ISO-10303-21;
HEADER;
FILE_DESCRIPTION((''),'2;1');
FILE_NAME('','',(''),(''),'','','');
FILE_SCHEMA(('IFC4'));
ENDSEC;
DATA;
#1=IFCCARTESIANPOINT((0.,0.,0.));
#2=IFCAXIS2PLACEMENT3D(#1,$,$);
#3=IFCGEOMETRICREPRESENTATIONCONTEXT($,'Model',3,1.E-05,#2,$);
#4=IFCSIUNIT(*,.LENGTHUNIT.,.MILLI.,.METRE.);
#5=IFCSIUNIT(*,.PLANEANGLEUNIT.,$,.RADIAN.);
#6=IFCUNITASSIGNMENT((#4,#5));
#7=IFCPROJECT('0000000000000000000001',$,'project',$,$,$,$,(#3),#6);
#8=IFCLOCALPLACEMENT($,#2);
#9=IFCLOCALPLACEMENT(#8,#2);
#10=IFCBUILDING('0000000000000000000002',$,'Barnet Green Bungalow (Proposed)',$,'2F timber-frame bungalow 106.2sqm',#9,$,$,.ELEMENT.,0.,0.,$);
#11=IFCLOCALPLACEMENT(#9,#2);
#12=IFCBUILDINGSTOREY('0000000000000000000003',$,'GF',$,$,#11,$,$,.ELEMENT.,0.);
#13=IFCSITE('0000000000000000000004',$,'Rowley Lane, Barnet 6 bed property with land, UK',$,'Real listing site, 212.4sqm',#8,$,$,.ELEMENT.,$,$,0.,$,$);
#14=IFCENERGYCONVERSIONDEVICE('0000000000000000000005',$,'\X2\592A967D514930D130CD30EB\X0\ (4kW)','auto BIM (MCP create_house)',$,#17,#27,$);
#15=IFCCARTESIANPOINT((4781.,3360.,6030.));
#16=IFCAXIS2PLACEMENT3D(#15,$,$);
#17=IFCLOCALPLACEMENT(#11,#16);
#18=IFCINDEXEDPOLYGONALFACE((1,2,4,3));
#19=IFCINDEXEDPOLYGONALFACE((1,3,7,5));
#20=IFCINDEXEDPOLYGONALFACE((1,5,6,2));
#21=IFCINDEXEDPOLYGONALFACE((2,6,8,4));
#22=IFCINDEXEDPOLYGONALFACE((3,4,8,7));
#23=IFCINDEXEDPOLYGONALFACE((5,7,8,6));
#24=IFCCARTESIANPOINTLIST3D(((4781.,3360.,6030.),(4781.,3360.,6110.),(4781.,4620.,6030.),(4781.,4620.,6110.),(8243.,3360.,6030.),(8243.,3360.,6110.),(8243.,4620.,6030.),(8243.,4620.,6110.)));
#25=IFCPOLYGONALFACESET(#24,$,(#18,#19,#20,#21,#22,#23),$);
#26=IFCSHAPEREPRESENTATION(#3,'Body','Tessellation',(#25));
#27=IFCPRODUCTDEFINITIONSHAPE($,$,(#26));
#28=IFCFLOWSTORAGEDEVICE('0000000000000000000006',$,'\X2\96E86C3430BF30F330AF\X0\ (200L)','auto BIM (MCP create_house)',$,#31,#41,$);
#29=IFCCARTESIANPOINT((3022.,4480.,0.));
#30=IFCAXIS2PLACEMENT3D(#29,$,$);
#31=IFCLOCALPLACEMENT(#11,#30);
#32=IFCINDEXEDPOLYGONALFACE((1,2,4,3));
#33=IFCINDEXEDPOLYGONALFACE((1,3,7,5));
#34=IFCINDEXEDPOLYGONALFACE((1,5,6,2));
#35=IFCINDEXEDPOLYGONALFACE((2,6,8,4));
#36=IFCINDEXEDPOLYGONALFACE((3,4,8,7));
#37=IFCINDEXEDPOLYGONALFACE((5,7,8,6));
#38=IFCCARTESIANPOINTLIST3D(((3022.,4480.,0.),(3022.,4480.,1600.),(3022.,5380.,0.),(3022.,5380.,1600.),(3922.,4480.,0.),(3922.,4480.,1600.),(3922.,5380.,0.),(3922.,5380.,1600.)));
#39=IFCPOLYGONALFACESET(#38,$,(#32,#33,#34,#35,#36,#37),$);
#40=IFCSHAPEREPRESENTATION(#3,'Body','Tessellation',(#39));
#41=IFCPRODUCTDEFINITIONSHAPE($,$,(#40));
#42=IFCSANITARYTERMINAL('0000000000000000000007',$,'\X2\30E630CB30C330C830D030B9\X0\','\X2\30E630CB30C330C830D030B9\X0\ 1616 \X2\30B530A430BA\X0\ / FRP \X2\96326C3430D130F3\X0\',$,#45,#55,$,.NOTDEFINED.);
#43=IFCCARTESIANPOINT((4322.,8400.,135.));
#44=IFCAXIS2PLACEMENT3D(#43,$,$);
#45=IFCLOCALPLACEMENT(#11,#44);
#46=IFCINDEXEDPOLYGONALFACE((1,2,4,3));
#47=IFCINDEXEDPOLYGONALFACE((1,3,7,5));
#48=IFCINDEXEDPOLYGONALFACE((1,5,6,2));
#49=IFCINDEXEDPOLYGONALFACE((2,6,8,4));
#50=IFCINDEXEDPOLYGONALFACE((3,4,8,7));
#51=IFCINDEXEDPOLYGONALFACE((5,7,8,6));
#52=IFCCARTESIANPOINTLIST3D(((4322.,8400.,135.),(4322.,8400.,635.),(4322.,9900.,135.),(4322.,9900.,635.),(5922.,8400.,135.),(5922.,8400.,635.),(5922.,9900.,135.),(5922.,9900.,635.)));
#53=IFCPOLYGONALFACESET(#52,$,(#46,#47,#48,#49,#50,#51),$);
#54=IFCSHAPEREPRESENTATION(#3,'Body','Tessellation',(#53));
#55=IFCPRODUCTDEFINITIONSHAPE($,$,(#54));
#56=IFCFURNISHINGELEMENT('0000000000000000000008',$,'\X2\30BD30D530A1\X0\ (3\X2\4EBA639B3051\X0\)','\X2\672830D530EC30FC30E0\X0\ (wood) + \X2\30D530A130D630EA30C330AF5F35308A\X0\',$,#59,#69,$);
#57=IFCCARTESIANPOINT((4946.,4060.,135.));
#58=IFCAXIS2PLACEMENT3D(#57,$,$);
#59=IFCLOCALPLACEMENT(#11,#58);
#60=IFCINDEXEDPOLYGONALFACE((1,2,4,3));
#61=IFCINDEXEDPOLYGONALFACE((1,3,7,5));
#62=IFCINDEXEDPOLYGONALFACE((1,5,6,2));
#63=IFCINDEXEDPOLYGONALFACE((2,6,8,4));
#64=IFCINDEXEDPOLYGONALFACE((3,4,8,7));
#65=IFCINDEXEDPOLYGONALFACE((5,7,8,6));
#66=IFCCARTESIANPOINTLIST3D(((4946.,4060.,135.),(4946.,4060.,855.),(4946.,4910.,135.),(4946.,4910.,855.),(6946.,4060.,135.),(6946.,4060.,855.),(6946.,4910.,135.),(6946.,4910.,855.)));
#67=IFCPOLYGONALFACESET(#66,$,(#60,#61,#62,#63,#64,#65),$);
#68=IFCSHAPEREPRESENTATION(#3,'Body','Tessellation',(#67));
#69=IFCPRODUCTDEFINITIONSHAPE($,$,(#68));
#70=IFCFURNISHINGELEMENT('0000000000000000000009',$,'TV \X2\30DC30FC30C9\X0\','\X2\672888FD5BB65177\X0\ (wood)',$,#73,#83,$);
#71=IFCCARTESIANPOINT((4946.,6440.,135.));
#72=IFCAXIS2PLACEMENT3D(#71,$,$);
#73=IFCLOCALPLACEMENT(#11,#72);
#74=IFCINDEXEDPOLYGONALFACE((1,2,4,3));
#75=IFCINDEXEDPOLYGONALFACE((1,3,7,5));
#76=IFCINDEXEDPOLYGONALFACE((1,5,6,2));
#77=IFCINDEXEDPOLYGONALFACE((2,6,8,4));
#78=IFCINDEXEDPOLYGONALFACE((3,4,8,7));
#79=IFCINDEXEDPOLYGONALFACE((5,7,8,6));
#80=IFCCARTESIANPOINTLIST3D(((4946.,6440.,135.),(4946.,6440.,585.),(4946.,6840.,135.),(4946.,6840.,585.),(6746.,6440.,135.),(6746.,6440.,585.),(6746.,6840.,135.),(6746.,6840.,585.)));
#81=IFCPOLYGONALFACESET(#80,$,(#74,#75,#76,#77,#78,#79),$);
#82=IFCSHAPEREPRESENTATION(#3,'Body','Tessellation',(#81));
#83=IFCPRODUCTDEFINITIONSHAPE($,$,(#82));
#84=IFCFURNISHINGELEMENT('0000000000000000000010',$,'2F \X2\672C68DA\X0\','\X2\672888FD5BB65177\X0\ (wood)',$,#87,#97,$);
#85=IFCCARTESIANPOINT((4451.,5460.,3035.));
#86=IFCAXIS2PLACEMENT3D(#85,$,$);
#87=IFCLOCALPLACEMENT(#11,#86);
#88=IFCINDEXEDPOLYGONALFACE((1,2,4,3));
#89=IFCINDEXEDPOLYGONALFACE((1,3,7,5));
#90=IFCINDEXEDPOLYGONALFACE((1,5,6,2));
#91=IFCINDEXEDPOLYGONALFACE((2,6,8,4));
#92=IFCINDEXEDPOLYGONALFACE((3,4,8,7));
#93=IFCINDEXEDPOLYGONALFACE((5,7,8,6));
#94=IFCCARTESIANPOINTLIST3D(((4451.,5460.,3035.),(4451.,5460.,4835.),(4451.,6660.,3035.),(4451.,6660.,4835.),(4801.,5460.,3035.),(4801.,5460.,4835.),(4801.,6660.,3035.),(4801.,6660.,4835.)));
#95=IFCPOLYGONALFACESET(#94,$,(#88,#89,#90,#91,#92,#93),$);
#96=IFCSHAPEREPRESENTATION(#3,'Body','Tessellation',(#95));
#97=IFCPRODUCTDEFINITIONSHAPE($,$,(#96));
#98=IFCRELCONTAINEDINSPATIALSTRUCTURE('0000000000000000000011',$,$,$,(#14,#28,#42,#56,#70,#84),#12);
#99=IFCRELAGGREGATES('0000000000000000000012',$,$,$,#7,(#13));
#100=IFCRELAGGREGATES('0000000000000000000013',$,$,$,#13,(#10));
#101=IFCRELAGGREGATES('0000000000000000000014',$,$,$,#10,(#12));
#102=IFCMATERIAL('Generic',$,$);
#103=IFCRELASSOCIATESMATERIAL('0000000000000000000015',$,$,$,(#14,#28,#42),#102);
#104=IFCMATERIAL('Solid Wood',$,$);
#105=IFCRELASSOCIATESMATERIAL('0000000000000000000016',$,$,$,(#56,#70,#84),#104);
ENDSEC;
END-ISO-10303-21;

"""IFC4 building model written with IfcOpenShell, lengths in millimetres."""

from ifc_helpers import new_model, si_unit, frame, frame_2d, origin, place, context, project, spatial, rectangle, extrude, material, element, save


model = new_model("IFC4")

# Units and contexts
model_context = context("Model", 3, precision=1e-05, world=origin())
ifc_project = project(units=[si_unit("LENGTHUNIT", "METRE", prefix="MILLI"), si_unit("PLANEANGLEUNIT", "RADIAN")], contexts=[model_context])

# Site, building, storey
site_placement = place(None, origin())
site = spatial("IfcSite", under=ifc_project, at=site_placement, Name="Rowley Lane, Barnet 6 bed property with land, UK", ObjectType="Real listing site, 212.4sqm", CompositionType="ELEMENT", RefElevation=0.0)
building_placement = place(site_placement, origin())
building = spatial("IfcBuilding", under=site, at=building_placement, Name="Barnet Green Bungalow (Proposed)", ObjectType="2F timber-frame bungalow 106.2sqm", CompositionType="ELEMENT", ElevationOfRefHeight=0.0, ElevationOfTerrain=0.0)
storey_placement = place(building_placement, origin())
storey = spatial("IfcBuildingStorey", under=building, at=storey_placement, Name="GF", CompositionType="ELEMENT", Elevation=0.0)

# Shared definitions
ifc_material_1 = material(Name="Solid Wood")

# Energy conversion device
ifc_material_2 = material(Name="Generic")
energy_conversion_device_placement = place(storey_placement, frame((4781.0, 3360.0, 6030.0)))
element("IfcEnergyConversionDevice", 1, at=energy_conversion_device_placement, inside=storey, material=ifc_material_2, Name="太陽光パネル (4kW)", Description="auto BIM (MCP create_house)", context=model_context, shape_type="SweptSolid", body=[
    extrude(rectangle(XDim=3462.0, YDim=1260.0, at=frame_2d((1731.0, 630.0))), frame((4781.0, 3360.0, 6030.0)), (0.0, 0.0, 1.0), 80.0),
])

# Flow storage device
flow_storage_device_placement = place(storey_placement, frame((3022.0, 4480.0, 0.0)))
element("IfcFlowStorageDevice", 2, at=flow_storage_device_placement, inside=storey, material=ifc_material_2, Name="雨水タンク (200L)", Description="auto BIM (MCP create_house)", context=model_context, shape_type="SweptSolid", body=[
    extrude(rectangle(XDim=900.0, YDim=900.0, at=frame_2d((450.0, 450.0))), frame((3022.0, 4480.0, 0.0)), (0.0, 0.0, 1.0), 1600.0),
])

# Sanitary terminal
sanitary_terminal_placement = place(storey_placement, frame((4322.0, 8400.0, 135.0)))
element("IfcSanitaryTerminal", 3, at=sanitary_terminal_placement, inside=storey, material=ifc_material_2, Name="ユニットバス", Description="ユニットバス 1616 サイズ / FRP 防水パン", PredefinedType="NOTDEFINED", context=model_context, shape_type="SweptSolid", body=[
    extrude(rectangle(XDim=1600.0, YDim=1500.0, at=frame_2d((800.0, 750.0))), frame((4322.0, 8400.0, 135.0)), (0.0, 0.0, 1.0), 500.0),
])

# Furnishing elements
furnishing_1_placement = place(storey_placement, frame((4946.0, 4060.0, 135.0)))
element("IfcFurnishingElement", 4, at=furnishing_1_placement, inside=storey, material=ifc_material_1, Name="ソファ (3人掛け)", Description="木フレーム (wood) + ファブリック張り", context=model_context, shape_type="SweptSolid", body=[
    extrude(rectangle(XDim=2000.0, YDim=850.0, at=frame_2d((1000.0, 425.0))), frame((4946.0, 4060.0, 135.0)), (0.0, 0.0, 1.0), 720.0),
])
furnishing_2_placement = place(storey_placement, frame((4946.0, 6440.0, 135.0)))
element("IfcFurnishingElement", 5, at=furnishing_2_placement, inside=storey, material=ifc_material_1, Name="TV ボード", Description="木製家具 (wood)", context=model_context, shape_type="SweptSolid", body=[
    extrude(rectangle(XDim=1800.0, YDim=400.0, at=frame_2d((900.0, 200.0))), frame((4946.0, 6440.0, 135.0)), (0.0, 0.0, 1.0), 450.0),
])
furnishing_3_placement = place(storey_placement, frame((4451.0, 5460.0, 3035.0)))
element("IfcFurnishingElement", 6, at=furnishing_3_placement, inside=storey, material=ifc_material_1, Name="2F 本棚", Description="木製家具 (wood)", context=model_context, shape_type="SweptSolid", body=[
    extrude(rectangle(XDim=350.0, YDim=1200.0, at=frame_2d((175.0, 600.0))), frame((4451.0, 5460.0, 3035.0)), (0.0, 0.0, 1.0), 1800.0),
])

save(model, "model.ifc")
